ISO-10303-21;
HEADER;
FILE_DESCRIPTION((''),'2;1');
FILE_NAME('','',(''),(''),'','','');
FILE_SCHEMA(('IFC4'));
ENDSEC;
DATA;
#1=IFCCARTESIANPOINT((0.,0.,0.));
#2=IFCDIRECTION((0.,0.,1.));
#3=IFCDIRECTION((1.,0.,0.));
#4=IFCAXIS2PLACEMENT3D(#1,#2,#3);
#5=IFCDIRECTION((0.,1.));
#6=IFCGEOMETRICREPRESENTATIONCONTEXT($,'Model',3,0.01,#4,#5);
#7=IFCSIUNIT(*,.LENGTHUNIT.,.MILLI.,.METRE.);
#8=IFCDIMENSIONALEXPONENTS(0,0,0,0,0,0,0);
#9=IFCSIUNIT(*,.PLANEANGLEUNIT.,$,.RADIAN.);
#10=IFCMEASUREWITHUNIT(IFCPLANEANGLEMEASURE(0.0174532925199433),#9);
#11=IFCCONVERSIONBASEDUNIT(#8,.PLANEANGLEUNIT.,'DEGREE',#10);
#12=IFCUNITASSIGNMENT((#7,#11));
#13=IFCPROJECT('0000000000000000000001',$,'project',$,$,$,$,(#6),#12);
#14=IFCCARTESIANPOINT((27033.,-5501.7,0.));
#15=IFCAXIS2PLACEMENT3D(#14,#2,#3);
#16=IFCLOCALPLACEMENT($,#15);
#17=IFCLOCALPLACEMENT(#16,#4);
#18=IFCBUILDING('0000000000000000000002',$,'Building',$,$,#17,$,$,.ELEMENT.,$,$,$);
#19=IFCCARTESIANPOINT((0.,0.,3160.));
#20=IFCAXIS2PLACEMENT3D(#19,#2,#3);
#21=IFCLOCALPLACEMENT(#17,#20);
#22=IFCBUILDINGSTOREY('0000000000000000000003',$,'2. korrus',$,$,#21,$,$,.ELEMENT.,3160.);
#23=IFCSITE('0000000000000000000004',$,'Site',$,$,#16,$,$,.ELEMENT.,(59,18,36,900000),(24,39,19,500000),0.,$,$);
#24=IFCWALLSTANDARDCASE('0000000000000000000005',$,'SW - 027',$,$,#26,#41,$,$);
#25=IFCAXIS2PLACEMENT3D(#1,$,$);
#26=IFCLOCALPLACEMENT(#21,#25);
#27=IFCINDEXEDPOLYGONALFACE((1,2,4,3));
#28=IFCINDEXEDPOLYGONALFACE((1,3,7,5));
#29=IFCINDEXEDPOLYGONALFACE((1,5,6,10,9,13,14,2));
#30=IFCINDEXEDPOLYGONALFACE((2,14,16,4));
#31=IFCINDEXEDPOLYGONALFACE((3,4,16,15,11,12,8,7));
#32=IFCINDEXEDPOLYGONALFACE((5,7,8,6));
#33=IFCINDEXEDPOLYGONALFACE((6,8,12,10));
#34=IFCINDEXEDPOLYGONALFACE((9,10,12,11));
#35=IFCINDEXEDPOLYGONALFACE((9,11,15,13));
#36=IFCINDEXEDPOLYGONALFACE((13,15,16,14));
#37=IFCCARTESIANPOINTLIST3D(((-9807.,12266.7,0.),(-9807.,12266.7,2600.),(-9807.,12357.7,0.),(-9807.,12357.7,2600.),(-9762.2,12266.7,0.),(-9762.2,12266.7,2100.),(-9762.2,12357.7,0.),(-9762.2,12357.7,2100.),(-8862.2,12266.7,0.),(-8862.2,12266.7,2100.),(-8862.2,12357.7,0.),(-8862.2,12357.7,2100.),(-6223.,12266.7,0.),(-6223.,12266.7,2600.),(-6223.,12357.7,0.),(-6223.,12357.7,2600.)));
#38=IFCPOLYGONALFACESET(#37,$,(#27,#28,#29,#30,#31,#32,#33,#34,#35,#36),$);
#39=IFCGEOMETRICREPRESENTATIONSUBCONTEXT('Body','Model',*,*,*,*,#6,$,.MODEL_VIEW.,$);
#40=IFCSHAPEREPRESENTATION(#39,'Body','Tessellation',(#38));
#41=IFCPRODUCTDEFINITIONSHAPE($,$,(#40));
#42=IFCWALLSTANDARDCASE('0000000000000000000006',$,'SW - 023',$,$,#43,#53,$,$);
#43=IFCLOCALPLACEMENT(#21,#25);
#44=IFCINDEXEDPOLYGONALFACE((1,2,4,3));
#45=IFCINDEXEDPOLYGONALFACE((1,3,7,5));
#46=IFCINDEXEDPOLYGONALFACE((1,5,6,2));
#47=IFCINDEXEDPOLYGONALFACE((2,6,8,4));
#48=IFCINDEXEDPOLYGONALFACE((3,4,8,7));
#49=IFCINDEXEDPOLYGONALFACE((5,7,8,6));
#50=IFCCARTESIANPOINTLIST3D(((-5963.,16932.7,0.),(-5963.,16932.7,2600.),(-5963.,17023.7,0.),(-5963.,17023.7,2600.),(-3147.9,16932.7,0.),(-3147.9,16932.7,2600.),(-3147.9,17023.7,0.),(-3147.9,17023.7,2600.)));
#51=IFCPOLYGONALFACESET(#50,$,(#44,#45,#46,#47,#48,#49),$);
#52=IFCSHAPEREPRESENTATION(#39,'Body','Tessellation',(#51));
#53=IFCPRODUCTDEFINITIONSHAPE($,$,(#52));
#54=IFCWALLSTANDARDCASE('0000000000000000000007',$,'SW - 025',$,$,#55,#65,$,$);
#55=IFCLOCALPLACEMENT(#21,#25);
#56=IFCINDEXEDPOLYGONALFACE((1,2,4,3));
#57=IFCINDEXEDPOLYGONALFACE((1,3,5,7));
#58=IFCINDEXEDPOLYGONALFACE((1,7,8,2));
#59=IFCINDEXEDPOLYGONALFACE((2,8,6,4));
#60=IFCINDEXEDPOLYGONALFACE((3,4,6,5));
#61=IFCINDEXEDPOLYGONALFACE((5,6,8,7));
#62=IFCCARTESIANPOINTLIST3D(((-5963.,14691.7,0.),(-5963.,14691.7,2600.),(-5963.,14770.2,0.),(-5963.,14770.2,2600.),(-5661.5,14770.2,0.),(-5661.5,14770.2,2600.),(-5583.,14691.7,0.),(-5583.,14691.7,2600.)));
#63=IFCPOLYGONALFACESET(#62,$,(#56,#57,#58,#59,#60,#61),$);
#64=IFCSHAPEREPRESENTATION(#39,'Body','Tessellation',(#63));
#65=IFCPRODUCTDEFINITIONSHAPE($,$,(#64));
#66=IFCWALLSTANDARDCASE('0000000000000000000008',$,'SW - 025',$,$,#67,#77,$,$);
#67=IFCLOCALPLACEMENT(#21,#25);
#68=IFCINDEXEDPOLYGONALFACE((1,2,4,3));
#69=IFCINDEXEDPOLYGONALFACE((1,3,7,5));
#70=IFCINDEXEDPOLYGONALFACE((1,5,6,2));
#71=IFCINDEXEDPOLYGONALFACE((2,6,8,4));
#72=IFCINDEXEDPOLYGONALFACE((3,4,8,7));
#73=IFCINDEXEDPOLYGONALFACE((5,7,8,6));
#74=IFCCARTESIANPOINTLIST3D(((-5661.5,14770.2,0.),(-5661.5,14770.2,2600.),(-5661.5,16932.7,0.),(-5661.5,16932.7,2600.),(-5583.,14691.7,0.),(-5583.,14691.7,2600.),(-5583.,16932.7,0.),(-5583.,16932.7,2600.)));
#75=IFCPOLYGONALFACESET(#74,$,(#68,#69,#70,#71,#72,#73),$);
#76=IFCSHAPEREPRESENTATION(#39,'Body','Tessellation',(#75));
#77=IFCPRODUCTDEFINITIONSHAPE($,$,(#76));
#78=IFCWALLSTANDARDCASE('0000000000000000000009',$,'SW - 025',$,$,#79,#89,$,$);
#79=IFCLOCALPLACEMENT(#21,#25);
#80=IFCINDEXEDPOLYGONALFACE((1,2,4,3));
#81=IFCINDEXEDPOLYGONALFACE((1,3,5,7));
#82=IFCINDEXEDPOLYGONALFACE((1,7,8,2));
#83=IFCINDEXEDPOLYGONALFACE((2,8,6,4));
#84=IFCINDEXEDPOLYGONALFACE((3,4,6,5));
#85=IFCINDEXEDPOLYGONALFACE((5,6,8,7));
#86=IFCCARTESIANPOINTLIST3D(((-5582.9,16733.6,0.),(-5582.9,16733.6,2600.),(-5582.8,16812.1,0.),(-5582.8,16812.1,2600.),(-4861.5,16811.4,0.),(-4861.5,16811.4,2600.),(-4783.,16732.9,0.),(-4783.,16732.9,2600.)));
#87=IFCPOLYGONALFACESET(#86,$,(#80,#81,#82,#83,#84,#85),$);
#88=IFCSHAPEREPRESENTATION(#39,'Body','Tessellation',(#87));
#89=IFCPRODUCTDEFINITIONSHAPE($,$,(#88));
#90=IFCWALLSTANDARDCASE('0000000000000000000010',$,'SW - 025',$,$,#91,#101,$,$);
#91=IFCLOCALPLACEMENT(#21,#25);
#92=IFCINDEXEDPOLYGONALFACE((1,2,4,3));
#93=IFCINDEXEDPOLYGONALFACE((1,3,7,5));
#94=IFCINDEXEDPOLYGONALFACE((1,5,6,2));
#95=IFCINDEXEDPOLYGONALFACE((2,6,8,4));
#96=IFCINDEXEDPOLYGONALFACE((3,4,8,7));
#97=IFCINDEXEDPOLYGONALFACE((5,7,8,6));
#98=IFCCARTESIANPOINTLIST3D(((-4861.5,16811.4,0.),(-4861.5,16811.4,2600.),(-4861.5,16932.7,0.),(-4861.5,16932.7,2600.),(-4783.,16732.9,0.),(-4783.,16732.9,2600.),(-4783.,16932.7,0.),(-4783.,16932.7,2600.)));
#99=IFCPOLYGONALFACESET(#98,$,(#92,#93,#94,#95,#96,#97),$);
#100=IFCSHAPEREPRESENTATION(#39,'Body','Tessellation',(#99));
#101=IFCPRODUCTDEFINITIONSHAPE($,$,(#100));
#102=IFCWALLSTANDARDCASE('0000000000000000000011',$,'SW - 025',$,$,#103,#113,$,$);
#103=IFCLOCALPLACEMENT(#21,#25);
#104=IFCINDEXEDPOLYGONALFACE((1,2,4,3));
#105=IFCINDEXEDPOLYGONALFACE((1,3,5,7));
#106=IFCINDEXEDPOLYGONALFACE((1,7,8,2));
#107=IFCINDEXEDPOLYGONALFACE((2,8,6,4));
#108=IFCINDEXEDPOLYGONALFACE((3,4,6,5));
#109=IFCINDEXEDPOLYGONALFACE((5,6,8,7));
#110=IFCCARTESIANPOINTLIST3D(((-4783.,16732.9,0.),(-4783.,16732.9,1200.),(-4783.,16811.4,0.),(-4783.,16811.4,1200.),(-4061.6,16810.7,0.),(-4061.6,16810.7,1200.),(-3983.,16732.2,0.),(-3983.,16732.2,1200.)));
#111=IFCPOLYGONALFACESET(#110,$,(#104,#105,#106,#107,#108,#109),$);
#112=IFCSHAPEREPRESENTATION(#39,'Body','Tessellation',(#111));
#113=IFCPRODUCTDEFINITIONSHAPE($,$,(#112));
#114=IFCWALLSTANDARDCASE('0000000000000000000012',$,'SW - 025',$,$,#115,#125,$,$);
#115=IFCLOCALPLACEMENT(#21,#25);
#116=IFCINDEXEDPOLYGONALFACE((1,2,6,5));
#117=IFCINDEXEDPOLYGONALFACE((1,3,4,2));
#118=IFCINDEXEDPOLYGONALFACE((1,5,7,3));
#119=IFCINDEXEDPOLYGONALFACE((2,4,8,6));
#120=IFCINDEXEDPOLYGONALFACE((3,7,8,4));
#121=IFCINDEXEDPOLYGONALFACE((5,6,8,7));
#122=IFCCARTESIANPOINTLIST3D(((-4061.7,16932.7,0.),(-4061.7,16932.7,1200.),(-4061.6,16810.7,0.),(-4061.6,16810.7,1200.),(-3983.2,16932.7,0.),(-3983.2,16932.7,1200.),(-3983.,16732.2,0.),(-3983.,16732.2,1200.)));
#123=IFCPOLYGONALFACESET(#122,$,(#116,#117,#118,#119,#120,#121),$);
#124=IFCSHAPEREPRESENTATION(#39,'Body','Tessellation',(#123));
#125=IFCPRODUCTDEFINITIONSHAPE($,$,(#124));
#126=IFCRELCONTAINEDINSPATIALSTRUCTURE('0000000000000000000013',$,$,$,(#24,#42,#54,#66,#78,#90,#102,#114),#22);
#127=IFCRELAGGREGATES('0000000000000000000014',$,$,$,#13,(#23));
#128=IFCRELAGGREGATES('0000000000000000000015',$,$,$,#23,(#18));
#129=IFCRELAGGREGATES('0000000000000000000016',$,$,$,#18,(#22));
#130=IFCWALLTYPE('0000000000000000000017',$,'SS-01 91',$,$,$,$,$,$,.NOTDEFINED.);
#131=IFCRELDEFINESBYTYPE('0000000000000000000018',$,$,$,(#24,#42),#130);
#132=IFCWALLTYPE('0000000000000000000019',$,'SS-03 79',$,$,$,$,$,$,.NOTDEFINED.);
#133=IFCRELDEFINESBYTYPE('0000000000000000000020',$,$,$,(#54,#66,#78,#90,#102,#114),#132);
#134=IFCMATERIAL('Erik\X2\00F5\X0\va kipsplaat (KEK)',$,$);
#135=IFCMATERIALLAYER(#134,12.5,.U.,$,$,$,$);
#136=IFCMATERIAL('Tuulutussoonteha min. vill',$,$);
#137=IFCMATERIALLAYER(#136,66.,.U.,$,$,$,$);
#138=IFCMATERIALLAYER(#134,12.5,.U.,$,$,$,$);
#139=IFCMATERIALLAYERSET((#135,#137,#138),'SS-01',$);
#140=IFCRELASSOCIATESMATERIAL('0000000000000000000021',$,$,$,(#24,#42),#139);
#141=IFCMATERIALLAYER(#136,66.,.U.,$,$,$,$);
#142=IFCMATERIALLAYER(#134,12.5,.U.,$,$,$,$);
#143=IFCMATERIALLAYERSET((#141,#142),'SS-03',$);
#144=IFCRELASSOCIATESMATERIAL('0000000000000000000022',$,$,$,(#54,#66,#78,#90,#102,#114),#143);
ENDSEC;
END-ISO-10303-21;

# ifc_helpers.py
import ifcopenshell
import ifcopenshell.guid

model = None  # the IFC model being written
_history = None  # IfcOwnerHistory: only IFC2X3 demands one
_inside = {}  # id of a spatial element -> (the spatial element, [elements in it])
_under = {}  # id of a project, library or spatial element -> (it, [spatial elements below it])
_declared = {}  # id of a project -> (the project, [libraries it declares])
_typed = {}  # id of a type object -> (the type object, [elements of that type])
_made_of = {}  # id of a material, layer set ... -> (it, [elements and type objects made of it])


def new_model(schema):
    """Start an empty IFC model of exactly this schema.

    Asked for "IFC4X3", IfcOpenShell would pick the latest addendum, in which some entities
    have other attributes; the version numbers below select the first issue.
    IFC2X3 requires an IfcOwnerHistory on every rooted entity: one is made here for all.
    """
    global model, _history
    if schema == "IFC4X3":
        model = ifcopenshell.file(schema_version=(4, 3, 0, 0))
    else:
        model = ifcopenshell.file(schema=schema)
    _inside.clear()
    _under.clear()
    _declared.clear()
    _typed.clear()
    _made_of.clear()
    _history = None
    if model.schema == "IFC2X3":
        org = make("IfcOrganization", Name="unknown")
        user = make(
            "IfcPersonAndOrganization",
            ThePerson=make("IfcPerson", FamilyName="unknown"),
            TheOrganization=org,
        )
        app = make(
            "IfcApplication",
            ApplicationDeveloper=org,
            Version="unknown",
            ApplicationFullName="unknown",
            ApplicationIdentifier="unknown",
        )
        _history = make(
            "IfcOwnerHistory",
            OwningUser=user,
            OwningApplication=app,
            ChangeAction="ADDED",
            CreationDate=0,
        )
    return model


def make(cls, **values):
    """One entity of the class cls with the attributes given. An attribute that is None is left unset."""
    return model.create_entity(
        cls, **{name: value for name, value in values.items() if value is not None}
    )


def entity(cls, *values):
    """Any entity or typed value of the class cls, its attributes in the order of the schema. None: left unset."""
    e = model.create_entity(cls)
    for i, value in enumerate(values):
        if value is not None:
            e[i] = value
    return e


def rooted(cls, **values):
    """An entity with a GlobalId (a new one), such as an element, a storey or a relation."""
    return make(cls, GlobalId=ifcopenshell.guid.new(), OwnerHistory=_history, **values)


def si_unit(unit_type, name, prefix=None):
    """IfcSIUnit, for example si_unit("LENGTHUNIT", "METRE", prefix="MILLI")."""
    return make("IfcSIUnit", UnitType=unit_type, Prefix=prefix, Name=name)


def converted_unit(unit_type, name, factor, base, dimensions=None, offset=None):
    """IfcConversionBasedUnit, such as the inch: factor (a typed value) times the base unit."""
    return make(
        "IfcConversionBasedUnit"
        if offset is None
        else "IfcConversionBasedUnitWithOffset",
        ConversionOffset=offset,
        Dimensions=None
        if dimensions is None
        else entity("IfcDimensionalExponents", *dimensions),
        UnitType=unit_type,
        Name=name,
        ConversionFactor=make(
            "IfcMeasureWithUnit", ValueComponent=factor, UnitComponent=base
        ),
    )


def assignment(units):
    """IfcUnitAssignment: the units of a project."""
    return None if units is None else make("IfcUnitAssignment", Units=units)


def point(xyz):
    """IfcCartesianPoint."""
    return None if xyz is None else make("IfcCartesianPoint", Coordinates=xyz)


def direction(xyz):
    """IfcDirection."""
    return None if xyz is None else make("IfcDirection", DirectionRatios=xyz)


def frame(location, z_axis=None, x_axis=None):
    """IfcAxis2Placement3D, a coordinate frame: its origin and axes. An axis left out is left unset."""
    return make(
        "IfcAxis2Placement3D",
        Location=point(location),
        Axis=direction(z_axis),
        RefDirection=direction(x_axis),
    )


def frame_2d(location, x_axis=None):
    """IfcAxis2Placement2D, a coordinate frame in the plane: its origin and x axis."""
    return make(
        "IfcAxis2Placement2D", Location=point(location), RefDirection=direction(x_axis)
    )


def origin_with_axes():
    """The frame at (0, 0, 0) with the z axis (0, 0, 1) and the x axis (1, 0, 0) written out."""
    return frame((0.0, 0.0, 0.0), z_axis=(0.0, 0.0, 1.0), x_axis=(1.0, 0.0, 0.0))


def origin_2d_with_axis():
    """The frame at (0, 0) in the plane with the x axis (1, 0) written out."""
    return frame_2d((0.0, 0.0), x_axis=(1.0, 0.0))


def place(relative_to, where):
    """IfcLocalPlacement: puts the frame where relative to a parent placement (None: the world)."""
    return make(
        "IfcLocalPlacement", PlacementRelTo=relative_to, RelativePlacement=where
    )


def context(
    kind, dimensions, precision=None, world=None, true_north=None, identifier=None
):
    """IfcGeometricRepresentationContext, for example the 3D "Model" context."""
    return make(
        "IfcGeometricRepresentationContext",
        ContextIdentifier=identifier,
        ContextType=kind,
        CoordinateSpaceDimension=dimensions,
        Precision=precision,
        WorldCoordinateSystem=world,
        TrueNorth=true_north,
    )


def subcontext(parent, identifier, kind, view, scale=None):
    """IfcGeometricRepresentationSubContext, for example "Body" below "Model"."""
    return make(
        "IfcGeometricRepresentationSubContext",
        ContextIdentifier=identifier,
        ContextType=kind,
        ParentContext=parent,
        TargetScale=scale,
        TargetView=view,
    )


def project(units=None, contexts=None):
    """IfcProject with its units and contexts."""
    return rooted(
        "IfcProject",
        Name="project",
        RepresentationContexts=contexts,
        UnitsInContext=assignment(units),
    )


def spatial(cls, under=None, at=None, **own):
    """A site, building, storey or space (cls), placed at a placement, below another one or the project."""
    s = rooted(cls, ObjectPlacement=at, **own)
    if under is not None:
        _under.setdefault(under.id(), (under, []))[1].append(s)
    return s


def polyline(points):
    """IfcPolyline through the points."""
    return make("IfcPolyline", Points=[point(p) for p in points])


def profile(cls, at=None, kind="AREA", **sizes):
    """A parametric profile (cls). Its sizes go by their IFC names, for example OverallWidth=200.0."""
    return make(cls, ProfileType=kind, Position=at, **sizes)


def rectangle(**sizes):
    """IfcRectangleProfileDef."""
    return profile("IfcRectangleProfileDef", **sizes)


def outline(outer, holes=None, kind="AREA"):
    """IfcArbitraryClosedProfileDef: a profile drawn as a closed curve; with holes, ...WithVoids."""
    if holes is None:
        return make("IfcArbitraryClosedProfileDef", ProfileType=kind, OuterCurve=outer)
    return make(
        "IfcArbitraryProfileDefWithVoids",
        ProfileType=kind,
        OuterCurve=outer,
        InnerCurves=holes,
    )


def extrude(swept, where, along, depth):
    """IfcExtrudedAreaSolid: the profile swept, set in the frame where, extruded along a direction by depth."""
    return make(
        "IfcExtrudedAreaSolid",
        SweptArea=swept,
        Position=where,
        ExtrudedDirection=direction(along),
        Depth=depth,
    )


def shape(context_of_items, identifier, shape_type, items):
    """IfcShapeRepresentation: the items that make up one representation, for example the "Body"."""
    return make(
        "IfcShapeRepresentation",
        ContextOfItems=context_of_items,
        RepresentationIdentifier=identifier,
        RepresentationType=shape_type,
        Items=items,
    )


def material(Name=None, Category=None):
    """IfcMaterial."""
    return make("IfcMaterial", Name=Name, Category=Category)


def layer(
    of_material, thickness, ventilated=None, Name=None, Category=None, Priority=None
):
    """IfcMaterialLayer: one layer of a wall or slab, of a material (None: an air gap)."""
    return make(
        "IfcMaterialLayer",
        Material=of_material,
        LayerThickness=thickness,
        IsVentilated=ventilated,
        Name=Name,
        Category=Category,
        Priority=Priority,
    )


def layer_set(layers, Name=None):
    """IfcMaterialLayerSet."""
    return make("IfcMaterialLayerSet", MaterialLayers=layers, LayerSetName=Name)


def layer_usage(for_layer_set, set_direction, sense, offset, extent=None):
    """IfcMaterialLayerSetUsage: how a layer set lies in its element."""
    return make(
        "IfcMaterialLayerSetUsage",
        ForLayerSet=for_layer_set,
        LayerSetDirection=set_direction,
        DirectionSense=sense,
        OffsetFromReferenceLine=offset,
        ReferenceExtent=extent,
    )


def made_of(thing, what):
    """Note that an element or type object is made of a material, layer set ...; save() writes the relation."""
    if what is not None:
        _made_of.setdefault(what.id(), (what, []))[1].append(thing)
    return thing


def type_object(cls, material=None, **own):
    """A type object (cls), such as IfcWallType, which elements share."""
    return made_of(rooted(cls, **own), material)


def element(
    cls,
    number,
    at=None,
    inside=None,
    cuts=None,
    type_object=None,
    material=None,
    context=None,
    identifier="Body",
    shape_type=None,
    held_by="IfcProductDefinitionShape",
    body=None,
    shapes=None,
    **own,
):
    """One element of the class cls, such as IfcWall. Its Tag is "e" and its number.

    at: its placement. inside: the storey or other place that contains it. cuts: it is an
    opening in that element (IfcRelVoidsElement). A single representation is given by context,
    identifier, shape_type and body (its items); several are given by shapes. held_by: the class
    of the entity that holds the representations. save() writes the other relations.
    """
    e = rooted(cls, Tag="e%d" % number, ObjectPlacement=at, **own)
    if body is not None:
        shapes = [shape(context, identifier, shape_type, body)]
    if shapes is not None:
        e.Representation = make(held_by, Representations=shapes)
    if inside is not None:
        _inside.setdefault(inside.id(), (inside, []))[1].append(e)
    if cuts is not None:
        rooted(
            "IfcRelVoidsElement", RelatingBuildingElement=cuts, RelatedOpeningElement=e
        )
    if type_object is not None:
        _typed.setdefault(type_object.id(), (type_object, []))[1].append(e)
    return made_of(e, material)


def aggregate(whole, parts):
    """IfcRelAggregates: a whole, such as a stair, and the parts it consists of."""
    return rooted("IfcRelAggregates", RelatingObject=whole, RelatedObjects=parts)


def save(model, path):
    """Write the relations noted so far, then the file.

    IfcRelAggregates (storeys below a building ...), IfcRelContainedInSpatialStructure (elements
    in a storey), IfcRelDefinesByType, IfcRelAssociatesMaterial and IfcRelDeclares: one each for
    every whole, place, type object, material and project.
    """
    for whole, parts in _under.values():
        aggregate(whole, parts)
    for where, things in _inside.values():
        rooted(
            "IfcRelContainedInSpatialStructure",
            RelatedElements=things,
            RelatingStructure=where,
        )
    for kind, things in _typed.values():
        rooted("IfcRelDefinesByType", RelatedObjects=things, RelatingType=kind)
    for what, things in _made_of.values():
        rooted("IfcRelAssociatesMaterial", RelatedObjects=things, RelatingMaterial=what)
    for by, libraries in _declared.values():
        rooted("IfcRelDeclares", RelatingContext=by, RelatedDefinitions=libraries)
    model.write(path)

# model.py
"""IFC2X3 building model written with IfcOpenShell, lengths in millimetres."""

from ifc_helpers import new_model, entity, si_unit, converted_unit, direction, frame, origin_with_axes, origin_2d_with_axis, place, context, subcontext, project, spatial, polyline, rectangle, outline, extrude, material, layer, layer_set, layer_usage, type_object, element, save


model = new_model("IFC2X3")

# Units and contexts
model_context = context("Model", 3, precision=0.01, world=origin_with_axes(), true_north=direction((0.0, 1.0)))
body_context = subcontext(model_context, "Body", "Model", "MODEL_VIEW")
ifc_project = project(units=[si_unit("LENGTHUNIT", "METRE", prefix="MILLI"), converted_unit("PLANEANGLEUNIT", "DEGREE", entity("IfcPlaneAngleMeasure", 0.0174532925199433), si_unit("PLANEANGLEUNIT", "RADIAN"), dimensions=[0, 0, 0, 0, 0, 0, 0])], contexts=[model_context])

# Site, building, storey
site_placement = place(None, frame((27033.0, -5501.7, 0.0), z_axis=(0.0, 0.0, 1.0), x_axis=(1.0, 0.0, 0.0)))
site = spatial("IfcSite", under=ifc_project, at=site_placement, Name="Site", CompositionType="ELEMENT", RefLatitude=(59, 18, 36, 900000), RefLongitude=(24, 39, 19, 500000), RefElevation=0.0)
building_placement = place(site_placement, origin_with_axes())
building = spatial("IfcBuilding", under=site, at=building_placement, Name="Building", CompositionType="ELEMENT")
storey_placement = place(building_placement, frame((0.0, 0.0, 3160.0), z_axis=(0.0, 0.0, 1.0), x_axis=(1.0, 0.0, 0.0)))
storey = spatial("IfcBuildingStorey", under=building, at=storey_placement, Name="2. korrus", CompositionType="ELEMENT", Elevation=3160.0)

# Shared definitions
ifc_material_1 = material(Name="Erikõva kipsplaat (KEK)")
ifc_layer_1 = layer(ifc_material_1, 12.5, ventilated="UNKNOWN")
ifc_material_2 = material(Name="Tuulutussoonteha min. vill")
ifc_layer_2 = layer(ifc_material_2, 66.0, ventilated="UNKNOWN")
ifc_layer_3 = layer(ifc_material_1, 12.5, ventilated="UNKNOWN")
ifc_layer_set_1 = layer_set([ifc_layer_1, ifc_layer_2, ifc_layer_3], Name="SS-01")
wall_type_1 = type_object("IfcWallType", Name="SS-01 91", PredefinedType="NOTDEFINED")

# Wall, opening
ifc_layer_usage_1 = layer_usage(ifc_layer_set_1, "AXIS2", "POSITIVE", -91.0)
wall_1_placement = place(storey_placement, frame((-9807.0, 12357.7, 0.0), z_axis=(0.0, 0.0, 1.0), x_axis=(1.0, 0.0, 0.0)))
wall_1 = element("IfcWallStandardCase", 1, at=wall_1_placement, inside=storey, type_object=wall_type_1, material=ifc_layer_usage_1, Name="SW - 027", context=body_context, shape_type="SweptSolid", body=[
    extrude(outline(polyline([(0.0, -91.0), (3584.0, -91.0), (3584.0, 0.0), (0.0, 0.0), (0.0, -91.0)])), origin_with_axes(), (0.0, 0.0, 1.0), 2600.0),
])
opening_1_placement = place(wall_1_placement, frame((494.8, 0.0, 0.0), z_axis=(0.0, 0.0, 1.0), x_axis=(1.0, 0.0, 0.0)))
element("IfcOpeningElement", 2, at=opening_1_placement, cuts=wall_1, context=body_context, shape_type="SweptSolid", body=[
    extrude(rectangle(XDim=900.0, YDim=2100.0, at=origin_2d_with_axis()), frame((0.0, 91.0, 1050.0), z_axis=(0.0, -1.0, 0.0), x_axis=(-1.0, 0.0, 0.0)), (0.0, 0.0, 1.0), 273.0),
    extrude(rectangle(XDim=974.0, YDim=2137.0, at=origin_2d_with_axis()), frame((0.0, -91.0, 1068.5), z_axis=(0.0, 1.0, 0.0), x_axis=(-1.0, 0.0, 0.0)), (0.0, 0.0, -1.0), 91.0),
])

# Walls
ifc_layer_usage_2 = layer_usage(ifc_layer_set_1, "AXIS2", "POSITIVE", -91.0)
wall_2_placement = place(storey_placement, frame((-3056.9, 16932.7, 0.0), z_axis=(0.0, 0.0, 1.0), x_axis=(-1.0, 0.0, 0.0)))
element("IfcWallStandardCase", 3, at=wall_2_placement, inside=storey, type_object=wall_type_1, material=ifc_layer_usage_2, Name="SW - 023", context=body_context, shape_type="SweptSolid", body=[
    extrude(outline(polyline([(91.0, -91.0), (2906.1, -91.0), (2906.1, 0.0), (91.0, 0.0), (91.0, -91.0)])), origin_with_axes(), (0.0, 0.0, 1.0), 2600.0),
])
ifc_layer_4 = layer(ifc_material_2, 66.0, ventilated="UNKNOWN")
ifc_layer_5 = layer(ifc_material_1, 12.5, ventilated="UNKNOWN")
ifc_layer_set_2 = layer_set([ifc_layer_4, ifc_layer_5], Name="SS-03")
ifc_layer_usage_3 = layer_usage(ifc_layer_set_2, "AXIS2", "NEGATIVE", 78.5)
wall_type_2 = type_object("IfcWallType", Name="SS-03 79", PredefinedType="NOTDEFINED")
wall_3_placement = place(storey_placement, frame((-5963.0, 14691.7, 0.0), z_axis=(0.0, 0.0, 1.0), x_axis=(1.0, 0.0, 0.0)))
element("IfcWallStandardCase", 4, at=wall_3_placement, inside=storey, type_object=wall_type_2, material=ifc_layer_usage_3, Name="SW - 025", context=body_context, shape_type="SweptSolid", body=[
    extrude(outline(polyline([(0.0, 0.0), (380.0, 0.0), (301.5, 78.5), (0.0, 78.5), (0.0, 0.0)])), origin_with_axes(), (0.0, 0.0, 1.0), 2600.0),
])
ifc_layer_usage_4 = layer_usage(ifc_layer_set_2, "AXIS2", "NEGATIVE", 78.5)
wall_4_placement = place(storey_placement, frame((-5583.0, 14691.7, 0.0), z_axis=(0.0, 0.0, 1.0), x_axis=(0.0, 1.0, 0.0)))
element("IfcWallStandardCase", 5, at=wall_4_placement, inside=storey, type_object=wall_type_2, material=ifc_layer_usage_4, Name="SW - 025", context=body_context, shape_type="SweptSolid", body=[
    extrude(outline(polyline([(0.0, 0.0), (2241.0, 0.0), (2241.0, 78.5), (78.5, 78.5), (0.0, 0.0)])), origin_with_axes(), (0.0, 0.0, 1.0), 2600.0),
])
ifc_layer_usage_5 = layer_usage(ifc_layer_set_2, "AXIS2", "NEGATIVE", 78.5)
wall_5_placement = place(storey_placement, frame((-5582.9, 16733.6, 0.0), z_axis=(0.0, 0.0, 1.0), x_axis=(1.0, -0.000859, 0.0)))
element("IfcWallStandardCase", 6, at=wall_5_placement, inside=storey, type_object=wall_type_2, material=ifc_layer_usage_5, Name="SW - 025", context=body_context, shape_type="SweptSolid", body=[
    extrude(outline(polyline([(0.0, 0.0), (799.9, 0.0), (721.3, 78.5), (0.0, 78.5), (0.0, 0.0)])), origin_with_axes(), (0.0, 0.0, 1.0), 2600.0),
])
ifc_layer_usage_6 = layer_usage(ifc_layer_set_2, "AXIS2", "NEGATIVE", 78.5)
wall_6_placement = place(storey_placement, frame((-4783.0, 16732.9, 0.0), z_axis=(0.0, 0.0, 1.0), x_axis=(0.0, 1.0, 0.0)))
element("IfcWallStandardCase", 7, at=wall_6_placement, inside=storey, type_object=wall_type_2, material=ifc_layer_usage_6, Name="SW - 025", context=body_context, shape_type="SweptSolid", body=[
    extrude(outline(polyline([(0.0, 0.0), (199.8, 0.0), (199.8, 78.5), (78.6, 78.5), (0.0, 0.0)])), origin_with_axes(), (0.0, 0.0, 1.0), 2600.0),
])
ifc_layer_usage_7 = layer_usage(ifc_layer_set_2, "AXIS2", "NEGATIVE", 78.5)
wall_7_placement = place(storey_placement, frame((-4783.0, 16732.9, 0.0), z_axis=(0.0, 0.0, 1.0), x_axis=(1.0, -0.000859, 0.0)))
element("IfcWallStandardCase", 8, at=wall_7_placement, inside=storey, type_object=wall_type_2, material=ifc_layer_usage_7, Name="SW - 025", context=body_context, shape_type="SweptSolid", body=[
    extrude(outline(polyline([(0.0, 0.0), (800.0, 0.0), (721.4, 78.5), (-0.1, 78.5), (0.0, 0.0)])), origin_with_axes(), (0.0, 0.0, 1.0), 1200.0),
])
ifc_layer_usage_8 = layer_usage(ifc_layer_set_2, "AXIS2", "NEGATIVE", 78.5)
wall_8_placement = place(storey_placement, frame((-3983.0, 16732.2, 0.0), z_axis=(0.0, 0.0, 1.0), x_axis=(-0.000638, 1.0, 0.0)))
element("IfcWallStandardCase", 9, at=wall_8_placement, inside=storey, type_object=wall_type_2, material=ifc_layer_usage_8, Name="SW - 025", context=body_context, shape_type="SweptSolid", body=[
    extrude(outline(polyline([(0.0, 0.0), (200.5, 0.0), (200.5, 78.5), (78.6, 78.5), (0.0, 0.0)])), origin_with_axes(), (0.0, 0.0, 1.0), 1200.0),
])

save(model, "model.ifc")
